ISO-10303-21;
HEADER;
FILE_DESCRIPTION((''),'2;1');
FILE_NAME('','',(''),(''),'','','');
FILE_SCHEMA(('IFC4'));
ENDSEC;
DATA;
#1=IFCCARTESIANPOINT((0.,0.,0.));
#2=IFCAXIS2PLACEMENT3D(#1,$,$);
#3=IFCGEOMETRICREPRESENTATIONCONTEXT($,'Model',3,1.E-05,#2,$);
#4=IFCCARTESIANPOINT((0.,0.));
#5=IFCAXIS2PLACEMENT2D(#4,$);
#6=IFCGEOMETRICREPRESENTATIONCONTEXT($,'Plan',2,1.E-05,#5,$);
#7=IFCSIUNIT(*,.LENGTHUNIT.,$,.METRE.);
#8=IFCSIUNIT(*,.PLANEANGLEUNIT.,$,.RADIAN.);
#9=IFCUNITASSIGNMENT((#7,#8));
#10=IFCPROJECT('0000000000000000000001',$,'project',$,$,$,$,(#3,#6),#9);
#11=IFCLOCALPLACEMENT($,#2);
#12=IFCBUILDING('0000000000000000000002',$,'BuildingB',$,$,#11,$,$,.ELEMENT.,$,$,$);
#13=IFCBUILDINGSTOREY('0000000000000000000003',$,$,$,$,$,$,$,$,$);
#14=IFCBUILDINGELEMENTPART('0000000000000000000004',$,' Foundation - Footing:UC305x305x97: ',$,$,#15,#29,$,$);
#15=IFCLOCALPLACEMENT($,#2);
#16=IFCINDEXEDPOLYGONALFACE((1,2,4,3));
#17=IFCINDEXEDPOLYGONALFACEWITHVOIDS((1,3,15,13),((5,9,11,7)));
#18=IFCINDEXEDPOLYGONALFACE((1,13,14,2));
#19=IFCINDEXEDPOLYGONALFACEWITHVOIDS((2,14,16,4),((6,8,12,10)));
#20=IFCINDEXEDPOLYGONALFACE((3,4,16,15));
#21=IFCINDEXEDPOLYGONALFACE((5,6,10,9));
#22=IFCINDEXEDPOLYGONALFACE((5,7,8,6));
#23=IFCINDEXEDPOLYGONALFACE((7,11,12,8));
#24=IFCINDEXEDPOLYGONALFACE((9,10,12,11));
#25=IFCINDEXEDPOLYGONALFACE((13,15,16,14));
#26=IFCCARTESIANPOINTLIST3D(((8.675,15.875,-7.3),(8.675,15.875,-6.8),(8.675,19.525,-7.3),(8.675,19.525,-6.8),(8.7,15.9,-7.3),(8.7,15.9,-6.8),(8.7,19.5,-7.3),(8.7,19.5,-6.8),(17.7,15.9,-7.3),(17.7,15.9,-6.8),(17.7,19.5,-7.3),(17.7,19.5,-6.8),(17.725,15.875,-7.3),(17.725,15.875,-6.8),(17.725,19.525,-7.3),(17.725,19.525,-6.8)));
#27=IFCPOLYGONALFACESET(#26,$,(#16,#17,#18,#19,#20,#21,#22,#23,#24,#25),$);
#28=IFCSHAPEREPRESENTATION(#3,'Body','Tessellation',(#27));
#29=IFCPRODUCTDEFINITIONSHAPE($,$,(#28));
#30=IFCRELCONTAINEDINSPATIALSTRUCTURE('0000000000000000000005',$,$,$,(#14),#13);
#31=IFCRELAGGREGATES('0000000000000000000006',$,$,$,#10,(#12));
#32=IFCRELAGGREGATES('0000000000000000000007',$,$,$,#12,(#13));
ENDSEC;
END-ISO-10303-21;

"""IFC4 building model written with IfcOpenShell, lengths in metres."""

from ifc_helpers import new_model, si_unit, origin, origin_2d, place, context, project, spatial, polyline, outline, extrude, element, save


model = new_model("IFC4")

# Units and contexts
model_context = context("Model", 3, precision=1e-05, world=origin())
plan_context = context("Plan", 2, precision=1e-05, world=origin_2d())
ifc_project = project(units=[si_unit("LENGTHUNIT", "METRE"), si_unit("PLANEANGLEUNIT", "RADIAN")], contexts=[model_context, plan_context])

# Building, storey
building_placement = place(None, origin())
building = spatial("IfcBuilding", under=ifc_project, at=building_placement, Name="BuildingB", CompositionType="ELEMENT")
storey = spatial("IfcBuildingStorey", under=building)

# Building element part, opening
building_element_part_1 = element("IfcBuildingElementPart", 1, inside=storey, Name=" Foundation - Footing:UC305x305x97: ", context=model_context, shape_type="SweptSolid", body=[
    extrude(outline(polyline([(17.725, 19.525, -7.3), (8.675, 19.525, -7.3), (8.675, 15.875, -7.3), (17.725, 15.875, -7.3), (17.725, 19.525, -7.3)])), None, (0.0, 0.0, 1.0), 0.5),
])
element("IfcOpeningElement", 2, inside=storey, cuts=building_element_part_1, context=model_context, shape_type="SweptSolid", body=[
    extrude(outline(polyline([(17.7, 19.5, -7.3), (8.7, 19.5, -7.3), (8.7, 15.9, -7.3), (17.7, 15.9, -7.3), (17.7, 19.5, -7.3)])), None, (0.0, 0.0, 1.0), 0.5),
])

save(model, "model.ifc")
